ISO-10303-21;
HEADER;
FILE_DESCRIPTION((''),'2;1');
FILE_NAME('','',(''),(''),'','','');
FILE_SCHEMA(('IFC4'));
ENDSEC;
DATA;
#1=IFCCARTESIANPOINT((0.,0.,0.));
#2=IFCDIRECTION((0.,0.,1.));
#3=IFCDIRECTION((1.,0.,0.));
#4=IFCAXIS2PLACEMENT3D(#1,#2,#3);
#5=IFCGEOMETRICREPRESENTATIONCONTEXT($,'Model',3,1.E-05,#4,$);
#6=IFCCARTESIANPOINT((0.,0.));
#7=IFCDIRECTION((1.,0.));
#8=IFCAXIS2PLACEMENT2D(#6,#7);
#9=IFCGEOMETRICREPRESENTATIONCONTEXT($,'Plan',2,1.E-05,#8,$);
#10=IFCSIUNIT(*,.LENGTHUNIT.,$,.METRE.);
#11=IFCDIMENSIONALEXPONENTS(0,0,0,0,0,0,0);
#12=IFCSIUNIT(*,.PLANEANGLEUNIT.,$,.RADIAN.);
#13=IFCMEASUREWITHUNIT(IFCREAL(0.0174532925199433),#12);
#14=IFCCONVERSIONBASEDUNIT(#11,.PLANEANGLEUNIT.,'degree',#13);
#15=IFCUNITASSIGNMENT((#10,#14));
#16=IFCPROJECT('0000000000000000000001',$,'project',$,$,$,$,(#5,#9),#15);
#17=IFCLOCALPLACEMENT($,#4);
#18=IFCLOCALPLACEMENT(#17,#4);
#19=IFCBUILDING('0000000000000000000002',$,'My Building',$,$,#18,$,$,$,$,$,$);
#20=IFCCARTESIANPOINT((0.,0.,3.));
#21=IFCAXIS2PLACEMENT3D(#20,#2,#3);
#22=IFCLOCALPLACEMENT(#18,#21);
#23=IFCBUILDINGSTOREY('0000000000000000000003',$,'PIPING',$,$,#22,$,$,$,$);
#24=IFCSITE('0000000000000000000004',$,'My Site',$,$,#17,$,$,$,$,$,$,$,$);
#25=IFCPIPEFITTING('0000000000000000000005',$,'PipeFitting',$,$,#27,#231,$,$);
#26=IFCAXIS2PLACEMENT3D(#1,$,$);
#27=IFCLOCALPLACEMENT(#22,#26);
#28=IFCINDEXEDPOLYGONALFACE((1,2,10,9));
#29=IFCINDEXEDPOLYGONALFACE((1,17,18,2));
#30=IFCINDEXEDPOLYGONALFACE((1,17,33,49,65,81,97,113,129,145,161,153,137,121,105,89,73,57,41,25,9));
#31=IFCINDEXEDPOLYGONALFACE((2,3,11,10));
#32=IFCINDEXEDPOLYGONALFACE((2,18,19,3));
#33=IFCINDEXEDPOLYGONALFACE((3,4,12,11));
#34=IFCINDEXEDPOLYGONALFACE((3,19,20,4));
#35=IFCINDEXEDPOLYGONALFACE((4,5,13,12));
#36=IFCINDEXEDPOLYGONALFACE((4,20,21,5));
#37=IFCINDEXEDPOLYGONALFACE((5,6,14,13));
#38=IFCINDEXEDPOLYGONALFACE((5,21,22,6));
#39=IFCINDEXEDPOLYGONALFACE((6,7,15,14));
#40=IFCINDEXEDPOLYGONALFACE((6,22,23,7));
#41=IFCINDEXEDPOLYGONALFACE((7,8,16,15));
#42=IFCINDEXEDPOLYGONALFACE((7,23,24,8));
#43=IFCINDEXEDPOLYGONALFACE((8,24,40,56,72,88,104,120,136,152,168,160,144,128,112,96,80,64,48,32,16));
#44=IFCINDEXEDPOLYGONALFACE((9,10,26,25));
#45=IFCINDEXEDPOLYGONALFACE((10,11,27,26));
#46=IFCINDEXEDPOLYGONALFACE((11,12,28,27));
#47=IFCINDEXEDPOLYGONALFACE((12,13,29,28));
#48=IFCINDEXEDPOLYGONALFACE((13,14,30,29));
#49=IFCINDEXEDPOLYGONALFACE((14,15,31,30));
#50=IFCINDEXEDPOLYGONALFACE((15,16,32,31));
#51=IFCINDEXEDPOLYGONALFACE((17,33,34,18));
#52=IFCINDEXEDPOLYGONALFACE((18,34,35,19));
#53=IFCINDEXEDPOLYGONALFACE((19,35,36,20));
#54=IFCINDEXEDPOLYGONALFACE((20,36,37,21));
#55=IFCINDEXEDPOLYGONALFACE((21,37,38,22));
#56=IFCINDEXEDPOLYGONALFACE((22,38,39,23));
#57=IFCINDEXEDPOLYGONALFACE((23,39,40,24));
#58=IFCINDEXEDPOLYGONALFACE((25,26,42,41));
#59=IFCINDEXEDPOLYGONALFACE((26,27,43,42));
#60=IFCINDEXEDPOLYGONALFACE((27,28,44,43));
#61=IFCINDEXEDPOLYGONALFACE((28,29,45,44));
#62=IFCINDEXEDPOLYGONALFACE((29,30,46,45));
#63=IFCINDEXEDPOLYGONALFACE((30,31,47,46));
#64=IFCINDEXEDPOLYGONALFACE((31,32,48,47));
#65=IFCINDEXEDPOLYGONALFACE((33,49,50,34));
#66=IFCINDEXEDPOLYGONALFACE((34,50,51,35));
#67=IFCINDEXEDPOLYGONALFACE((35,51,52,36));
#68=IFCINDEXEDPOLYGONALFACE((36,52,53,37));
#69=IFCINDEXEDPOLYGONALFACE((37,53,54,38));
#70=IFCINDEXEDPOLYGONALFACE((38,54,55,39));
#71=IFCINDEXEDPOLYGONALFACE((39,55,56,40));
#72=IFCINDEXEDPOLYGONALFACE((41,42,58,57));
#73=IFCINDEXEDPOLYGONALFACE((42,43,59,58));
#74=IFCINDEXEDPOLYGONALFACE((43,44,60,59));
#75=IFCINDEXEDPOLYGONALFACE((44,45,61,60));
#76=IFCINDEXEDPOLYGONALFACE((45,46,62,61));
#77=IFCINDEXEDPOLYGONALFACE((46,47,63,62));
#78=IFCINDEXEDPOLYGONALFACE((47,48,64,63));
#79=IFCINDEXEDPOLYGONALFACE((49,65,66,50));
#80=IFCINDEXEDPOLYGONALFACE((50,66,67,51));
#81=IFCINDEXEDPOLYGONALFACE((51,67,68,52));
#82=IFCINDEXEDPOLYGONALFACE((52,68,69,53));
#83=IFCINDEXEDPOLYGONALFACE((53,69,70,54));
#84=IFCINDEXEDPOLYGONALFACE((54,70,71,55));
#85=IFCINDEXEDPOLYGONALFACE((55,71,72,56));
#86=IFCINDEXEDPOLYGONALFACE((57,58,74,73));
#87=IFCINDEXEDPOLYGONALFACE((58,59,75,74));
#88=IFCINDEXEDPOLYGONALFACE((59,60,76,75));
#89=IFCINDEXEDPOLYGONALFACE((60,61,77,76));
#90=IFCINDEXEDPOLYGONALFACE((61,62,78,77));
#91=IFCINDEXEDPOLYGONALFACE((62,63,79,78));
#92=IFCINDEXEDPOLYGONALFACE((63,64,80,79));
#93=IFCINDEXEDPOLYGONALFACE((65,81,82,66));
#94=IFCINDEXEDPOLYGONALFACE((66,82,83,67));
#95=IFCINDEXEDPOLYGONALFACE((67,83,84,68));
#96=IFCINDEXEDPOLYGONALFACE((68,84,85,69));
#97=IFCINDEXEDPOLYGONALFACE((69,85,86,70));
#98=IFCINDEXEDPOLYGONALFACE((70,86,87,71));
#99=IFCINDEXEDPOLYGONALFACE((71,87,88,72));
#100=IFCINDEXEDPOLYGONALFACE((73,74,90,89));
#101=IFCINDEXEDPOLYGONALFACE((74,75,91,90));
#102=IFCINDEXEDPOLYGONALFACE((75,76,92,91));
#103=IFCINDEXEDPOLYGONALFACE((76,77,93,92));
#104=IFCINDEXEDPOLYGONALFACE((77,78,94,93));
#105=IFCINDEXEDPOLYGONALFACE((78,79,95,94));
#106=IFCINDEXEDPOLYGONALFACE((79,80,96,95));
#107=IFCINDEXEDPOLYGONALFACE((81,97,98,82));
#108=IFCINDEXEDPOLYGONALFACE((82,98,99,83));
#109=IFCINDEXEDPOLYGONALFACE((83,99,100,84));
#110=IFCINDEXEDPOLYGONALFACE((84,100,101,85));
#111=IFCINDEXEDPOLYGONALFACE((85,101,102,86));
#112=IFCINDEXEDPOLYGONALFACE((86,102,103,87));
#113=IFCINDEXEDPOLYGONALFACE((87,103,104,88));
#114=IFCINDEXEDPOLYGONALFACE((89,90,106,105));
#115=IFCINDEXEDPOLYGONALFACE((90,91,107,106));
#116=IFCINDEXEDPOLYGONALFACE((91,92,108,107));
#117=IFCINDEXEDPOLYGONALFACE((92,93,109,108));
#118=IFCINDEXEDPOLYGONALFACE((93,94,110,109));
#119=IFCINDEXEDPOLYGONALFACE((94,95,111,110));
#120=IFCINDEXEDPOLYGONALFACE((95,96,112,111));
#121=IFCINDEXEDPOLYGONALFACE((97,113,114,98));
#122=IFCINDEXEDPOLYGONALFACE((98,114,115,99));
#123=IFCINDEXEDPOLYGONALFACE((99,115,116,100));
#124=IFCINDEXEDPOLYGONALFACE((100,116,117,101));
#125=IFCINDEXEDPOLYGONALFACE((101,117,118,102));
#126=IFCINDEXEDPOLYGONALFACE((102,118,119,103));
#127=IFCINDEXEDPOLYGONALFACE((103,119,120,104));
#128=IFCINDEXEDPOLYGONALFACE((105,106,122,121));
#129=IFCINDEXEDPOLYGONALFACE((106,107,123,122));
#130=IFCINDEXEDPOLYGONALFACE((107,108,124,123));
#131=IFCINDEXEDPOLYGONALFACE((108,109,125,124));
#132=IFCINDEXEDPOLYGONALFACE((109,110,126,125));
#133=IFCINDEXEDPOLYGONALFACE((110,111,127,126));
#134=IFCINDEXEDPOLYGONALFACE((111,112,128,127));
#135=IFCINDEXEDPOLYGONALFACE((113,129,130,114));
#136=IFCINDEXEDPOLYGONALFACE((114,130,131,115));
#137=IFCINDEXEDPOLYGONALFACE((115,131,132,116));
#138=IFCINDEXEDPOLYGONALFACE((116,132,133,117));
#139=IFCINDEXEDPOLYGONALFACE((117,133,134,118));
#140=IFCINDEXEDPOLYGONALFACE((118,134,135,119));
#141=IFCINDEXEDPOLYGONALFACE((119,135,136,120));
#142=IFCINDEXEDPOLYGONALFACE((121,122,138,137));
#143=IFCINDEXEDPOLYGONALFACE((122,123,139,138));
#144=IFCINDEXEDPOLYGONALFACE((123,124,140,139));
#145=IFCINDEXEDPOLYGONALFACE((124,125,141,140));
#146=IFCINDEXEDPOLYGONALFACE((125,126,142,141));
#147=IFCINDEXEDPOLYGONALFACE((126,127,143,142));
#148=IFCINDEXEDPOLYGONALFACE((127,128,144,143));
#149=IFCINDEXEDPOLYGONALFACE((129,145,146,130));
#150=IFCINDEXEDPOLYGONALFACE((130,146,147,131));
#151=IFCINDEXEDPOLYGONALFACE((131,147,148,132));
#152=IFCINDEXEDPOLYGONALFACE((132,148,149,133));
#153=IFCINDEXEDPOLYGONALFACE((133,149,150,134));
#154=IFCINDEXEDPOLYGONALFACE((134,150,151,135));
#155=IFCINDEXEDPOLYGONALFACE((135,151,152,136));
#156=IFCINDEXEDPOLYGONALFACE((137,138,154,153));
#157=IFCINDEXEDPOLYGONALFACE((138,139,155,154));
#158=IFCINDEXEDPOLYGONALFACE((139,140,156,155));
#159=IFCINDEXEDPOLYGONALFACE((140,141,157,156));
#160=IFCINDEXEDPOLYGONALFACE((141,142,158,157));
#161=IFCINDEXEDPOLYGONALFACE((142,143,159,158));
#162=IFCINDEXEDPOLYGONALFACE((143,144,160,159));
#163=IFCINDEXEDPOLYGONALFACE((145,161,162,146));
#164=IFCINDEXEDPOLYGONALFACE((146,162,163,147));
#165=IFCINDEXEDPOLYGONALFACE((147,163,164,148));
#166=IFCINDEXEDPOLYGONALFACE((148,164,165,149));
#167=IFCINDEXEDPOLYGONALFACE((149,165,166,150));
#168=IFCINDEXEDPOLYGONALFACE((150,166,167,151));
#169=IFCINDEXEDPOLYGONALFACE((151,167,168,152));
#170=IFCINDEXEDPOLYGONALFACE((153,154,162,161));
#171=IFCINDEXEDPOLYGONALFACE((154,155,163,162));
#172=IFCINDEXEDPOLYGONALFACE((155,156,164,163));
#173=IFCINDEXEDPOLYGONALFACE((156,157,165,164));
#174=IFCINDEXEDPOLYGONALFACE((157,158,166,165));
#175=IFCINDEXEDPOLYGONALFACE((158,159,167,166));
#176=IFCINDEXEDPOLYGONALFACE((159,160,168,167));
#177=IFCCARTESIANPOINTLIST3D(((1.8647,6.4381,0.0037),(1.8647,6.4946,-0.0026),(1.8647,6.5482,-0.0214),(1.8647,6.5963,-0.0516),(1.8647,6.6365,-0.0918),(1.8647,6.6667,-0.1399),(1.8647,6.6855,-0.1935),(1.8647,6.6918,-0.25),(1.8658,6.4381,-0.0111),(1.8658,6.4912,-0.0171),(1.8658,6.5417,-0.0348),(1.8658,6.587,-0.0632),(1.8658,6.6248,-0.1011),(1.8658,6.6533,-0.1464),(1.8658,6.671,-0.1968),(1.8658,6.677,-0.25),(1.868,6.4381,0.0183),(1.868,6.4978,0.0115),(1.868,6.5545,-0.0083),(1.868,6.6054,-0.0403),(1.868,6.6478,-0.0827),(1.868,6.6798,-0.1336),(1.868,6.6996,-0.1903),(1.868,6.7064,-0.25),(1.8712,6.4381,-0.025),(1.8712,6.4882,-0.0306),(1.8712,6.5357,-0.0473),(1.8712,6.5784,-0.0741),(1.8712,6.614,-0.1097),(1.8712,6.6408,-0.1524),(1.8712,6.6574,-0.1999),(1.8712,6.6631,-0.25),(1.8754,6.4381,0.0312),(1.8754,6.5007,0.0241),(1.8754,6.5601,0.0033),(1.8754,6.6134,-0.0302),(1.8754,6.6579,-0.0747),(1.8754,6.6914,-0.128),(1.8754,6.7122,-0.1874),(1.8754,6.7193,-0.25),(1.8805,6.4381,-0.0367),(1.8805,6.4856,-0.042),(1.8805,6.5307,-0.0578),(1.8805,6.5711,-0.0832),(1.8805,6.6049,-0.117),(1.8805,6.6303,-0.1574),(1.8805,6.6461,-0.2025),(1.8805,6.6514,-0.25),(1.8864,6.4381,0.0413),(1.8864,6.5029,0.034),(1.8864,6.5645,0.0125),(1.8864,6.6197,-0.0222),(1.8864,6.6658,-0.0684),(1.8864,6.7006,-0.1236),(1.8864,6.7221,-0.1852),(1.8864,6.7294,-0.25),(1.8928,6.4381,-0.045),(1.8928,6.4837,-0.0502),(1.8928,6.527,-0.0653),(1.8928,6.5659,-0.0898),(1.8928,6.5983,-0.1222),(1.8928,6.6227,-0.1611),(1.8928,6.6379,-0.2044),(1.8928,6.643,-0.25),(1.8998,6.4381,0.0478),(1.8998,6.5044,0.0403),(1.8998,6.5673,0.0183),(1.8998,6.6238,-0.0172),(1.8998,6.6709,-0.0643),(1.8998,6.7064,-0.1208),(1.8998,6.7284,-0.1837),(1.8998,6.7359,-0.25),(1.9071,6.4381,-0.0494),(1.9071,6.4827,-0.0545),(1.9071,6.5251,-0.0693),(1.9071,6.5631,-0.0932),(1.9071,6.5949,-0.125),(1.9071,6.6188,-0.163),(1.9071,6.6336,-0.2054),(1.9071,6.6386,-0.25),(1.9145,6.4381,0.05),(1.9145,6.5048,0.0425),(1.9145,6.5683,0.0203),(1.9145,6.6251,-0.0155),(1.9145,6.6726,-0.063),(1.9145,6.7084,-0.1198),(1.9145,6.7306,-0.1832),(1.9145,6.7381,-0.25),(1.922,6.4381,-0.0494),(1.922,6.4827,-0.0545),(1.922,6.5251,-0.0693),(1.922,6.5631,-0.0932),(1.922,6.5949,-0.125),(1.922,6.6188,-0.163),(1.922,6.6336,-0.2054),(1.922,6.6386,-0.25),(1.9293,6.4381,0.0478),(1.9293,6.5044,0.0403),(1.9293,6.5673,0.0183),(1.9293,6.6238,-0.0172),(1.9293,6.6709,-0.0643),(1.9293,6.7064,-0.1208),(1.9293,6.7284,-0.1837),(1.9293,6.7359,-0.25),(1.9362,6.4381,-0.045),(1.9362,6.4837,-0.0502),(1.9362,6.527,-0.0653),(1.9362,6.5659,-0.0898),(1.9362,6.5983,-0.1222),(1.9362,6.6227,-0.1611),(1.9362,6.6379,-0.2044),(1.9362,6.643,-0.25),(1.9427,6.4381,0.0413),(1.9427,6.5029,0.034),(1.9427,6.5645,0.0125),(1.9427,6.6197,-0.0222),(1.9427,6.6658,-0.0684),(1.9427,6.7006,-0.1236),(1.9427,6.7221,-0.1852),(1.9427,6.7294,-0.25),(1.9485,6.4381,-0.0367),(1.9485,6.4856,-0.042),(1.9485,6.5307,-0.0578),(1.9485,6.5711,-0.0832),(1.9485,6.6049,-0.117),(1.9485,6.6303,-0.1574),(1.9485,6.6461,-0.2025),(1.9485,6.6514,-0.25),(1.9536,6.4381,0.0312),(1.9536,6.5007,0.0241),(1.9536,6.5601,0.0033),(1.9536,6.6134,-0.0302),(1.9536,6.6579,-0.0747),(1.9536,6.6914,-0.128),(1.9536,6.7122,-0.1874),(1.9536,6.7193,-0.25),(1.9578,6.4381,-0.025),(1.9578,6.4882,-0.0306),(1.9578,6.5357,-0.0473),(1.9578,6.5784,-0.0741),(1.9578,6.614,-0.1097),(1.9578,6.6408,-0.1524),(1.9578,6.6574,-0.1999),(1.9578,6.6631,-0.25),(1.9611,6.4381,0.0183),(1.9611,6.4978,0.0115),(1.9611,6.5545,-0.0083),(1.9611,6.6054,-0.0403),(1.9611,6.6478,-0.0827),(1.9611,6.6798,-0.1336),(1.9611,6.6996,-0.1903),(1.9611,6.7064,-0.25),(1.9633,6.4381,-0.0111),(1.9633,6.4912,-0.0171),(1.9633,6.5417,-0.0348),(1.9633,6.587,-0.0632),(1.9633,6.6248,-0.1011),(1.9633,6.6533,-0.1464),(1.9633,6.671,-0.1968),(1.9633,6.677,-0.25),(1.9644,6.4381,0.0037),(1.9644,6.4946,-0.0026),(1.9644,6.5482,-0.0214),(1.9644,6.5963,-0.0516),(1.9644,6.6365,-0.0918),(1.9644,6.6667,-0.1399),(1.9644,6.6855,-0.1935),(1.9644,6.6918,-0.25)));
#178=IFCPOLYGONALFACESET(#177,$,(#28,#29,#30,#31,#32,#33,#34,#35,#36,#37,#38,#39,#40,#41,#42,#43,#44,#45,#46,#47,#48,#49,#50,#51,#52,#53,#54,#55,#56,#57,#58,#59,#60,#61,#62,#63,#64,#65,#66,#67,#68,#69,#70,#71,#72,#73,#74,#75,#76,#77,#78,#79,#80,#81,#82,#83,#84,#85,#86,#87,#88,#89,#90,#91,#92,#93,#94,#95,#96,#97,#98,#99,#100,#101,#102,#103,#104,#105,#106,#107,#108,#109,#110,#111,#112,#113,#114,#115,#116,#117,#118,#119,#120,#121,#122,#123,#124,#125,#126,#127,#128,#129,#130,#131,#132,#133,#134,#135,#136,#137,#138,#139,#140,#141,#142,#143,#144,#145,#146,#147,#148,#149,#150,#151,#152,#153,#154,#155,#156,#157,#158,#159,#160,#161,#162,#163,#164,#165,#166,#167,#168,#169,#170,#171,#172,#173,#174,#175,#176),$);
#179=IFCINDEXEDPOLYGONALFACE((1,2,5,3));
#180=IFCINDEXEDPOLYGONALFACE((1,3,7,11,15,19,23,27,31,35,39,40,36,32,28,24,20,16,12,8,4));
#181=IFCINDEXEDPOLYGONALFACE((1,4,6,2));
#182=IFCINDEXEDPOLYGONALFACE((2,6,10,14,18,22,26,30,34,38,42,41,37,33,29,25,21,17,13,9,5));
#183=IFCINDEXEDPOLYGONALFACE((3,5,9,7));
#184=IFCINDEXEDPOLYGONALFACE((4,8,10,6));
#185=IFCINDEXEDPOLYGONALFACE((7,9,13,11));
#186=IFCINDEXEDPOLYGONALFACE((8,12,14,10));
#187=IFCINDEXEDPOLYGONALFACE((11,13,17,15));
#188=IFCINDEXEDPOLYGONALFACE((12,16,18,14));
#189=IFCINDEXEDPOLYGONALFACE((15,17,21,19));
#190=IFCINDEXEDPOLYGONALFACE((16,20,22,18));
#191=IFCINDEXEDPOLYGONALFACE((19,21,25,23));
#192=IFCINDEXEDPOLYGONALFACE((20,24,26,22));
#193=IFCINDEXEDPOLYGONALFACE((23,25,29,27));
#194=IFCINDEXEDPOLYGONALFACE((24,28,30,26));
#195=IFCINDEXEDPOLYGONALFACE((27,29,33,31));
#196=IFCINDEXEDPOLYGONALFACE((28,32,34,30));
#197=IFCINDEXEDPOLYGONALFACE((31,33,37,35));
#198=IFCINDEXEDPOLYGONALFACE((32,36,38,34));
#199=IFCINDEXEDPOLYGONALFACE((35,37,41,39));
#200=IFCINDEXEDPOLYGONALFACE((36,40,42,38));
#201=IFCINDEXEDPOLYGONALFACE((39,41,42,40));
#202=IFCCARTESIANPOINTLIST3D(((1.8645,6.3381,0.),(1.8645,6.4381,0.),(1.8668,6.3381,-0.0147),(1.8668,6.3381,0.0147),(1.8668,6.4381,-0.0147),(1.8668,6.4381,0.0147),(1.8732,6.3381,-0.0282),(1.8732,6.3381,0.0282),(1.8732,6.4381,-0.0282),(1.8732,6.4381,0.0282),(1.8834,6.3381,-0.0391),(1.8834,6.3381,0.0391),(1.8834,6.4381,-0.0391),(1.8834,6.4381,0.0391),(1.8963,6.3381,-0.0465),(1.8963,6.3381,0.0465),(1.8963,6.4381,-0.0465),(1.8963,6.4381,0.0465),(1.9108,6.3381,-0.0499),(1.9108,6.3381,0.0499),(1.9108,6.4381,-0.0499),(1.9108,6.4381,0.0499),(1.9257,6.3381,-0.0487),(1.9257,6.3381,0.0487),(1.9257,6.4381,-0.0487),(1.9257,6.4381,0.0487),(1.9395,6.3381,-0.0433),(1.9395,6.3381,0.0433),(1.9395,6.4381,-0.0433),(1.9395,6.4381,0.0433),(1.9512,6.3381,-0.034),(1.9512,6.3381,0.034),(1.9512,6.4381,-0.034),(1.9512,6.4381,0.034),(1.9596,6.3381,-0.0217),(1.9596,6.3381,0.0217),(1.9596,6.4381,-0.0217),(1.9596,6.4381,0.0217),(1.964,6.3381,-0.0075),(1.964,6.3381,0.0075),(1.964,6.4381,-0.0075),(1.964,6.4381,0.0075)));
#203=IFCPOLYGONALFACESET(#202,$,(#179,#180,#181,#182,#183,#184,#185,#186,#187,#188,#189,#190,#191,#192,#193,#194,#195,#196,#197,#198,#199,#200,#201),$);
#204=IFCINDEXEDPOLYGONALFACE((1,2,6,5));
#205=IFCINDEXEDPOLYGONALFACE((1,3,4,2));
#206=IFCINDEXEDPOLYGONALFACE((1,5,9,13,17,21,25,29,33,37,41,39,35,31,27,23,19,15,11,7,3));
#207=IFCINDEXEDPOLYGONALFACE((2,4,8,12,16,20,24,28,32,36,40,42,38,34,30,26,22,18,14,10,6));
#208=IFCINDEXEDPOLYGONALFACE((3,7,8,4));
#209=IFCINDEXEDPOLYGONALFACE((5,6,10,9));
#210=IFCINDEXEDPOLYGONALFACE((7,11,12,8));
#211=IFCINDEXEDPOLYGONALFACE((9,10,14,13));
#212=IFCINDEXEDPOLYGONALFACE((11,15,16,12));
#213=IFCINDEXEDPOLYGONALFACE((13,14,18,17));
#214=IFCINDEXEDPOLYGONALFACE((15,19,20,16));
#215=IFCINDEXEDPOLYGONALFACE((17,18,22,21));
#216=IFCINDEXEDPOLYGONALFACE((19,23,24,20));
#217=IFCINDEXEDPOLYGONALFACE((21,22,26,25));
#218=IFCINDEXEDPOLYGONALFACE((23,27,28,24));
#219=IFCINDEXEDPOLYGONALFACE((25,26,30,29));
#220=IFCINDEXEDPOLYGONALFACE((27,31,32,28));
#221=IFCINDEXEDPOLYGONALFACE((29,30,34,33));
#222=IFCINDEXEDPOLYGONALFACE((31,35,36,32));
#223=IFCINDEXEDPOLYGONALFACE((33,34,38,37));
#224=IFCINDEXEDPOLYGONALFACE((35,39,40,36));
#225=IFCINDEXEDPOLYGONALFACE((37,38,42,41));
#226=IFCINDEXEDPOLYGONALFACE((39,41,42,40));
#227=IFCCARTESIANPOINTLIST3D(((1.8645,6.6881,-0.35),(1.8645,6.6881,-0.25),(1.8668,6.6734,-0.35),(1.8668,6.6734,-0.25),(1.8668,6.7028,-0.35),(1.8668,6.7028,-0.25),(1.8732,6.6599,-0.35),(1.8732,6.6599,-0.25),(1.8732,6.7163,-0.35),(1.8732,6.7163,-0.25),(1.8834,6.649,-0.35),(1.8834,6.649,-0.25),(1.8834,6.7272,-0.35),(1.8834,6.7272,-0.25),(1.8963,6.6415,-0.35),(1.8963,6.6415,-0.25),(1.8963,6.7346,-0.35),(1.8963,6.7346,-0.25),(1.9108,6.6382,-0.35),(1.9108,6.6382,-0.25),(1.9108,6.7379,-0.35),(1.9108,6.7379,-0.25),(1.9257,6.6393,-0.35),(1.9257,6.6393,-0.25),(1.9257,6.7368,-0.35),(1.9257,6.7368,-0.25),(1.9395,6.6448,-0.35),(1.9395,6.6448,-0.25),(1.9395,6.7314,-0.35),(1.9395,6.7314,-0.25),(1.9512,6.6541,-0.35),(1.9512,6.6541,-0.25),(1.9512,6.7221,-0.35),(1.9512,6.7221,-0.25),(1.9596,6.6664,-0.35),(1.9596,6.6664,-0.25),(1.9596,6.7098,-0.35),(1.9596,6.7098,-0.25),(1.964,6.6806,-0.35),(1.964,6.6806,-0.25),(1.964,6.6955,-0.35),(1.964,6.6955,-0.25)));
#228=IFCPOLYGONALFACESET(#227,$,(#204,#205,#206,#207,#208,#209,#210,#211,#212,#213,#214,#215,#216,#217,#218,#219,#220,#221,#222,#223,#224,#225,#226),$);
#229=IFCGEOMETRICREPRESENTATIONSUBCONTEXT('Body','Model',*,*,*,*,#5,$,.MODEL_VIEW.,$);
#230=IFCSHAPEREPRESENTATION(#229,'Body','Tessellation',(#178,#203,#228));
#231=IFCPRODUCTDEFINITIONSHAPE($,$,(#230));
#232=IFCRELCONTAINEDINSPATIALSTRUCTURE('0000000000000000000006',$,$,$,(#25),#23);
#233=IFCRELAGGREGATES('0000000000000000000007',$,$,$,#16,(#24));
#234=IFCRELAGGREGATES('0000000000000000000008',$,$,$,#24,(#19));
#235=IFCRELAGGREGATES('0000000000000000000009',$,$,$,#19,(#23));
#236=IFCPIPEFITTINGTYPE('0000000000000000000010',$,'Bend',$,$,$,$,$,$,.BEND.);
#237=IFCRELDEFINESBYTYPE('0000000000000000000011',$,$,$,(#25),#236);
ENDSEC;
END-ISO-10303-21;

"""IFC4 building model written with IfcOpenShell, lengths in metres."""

from ifc_helpers import new_model, entity, si_unit, converted_unit, frame, origin_with_axes, origin_2d_with_axis, place, context, subcontext, project, spatial, circle, extrude, source, transform, mapped, type_object, type_shapes, element, save


model = new_model("IFC4")

# Units and contexts
model_context = context("Model", 3, precision=1e-05, world=origin_with_axes())
plan_context = context("Plan", 2, precision=1e-05, world=origin_2d_with_axis())
body_context = subcontext(model_context, "Body", "Model", "MODEL_VIEW")
ifc_project = project(units=[si_unit("LENGTHUNIT", "METRE"), converted_unit("PLANEANGLEUNIT", "degree", entity("IfcReal", 0.0174532925199433), si_unit("PLANEANGLEUNIT", "RADIAN"), dimensions=[0, 0, 0, 0, 0, 0, 0])], contexts=[model_context, plan_context])

# Site, building, storey
site_placement = place(None, origin_with_axes())
site = spatial("IfcSite", under=ifc_project, at=site_placement, Name="My Site")
building_placement = place(site_placement, origin_with_axes())
building = spatial("IfcBuilding", under=site, at=building_placement, Name="My Building")
storey_placement = place(building_placement, frame((0.0, 0.0, 3.0), z_axis=(0.0, 0.0, 1.0), x_axis=(1.0, 0.0, 0.0)))
storey = spatial("IfcBuildingStorey", under=building, at=storey_placement, Name="PIPING")

# Pipe fitting
pipe_fitting_type = type_object("IfcPipeFittingType", Name="Bend", PredefinedType="BEND")
shared_shape = source(origin_with_axes(), body_context, "Body", "SolidModel", [
    entity("IfcSweptDiskSolid", entity("IfcIndexedPolyCurve", entity("IfcCartesianPointList3D", [[0.0, 0.0, 0.1], [0.0, -0.0732, 0.2768], [0.0, -0.25, 0.35]]), [entity("IfcArcIndex", [1, 2, 3])]), 0.05),
    extrude(circle(Radius=0.05), origin_with_axes(), (0.0, 0.0, 1.0), 0.1),
    extrude(circle(Radius=0.05), frame((0.0, -0.25, 0.35), z_axis=(0.0, -1.0, 0.0), x_axis=(1.0, 0.0, 0.0)), (0.0, 0.0, 1.0), 0.1),
])
type_shapes(pipe_fitting_type, [shared_shape])
for number, where, z_axis, x_axis, name in (
    (1, (1.9145, 6.3381, 0.0), (0.0, 1.0, 0.0), (-1.0, 0.0, 0.0), "PipeFitting"),
):
    element("IfcPipeFitting", number, at=place(storey_placement, frame(where, z_axis=z_axis, x_axis=x_axis)), inside=storey, type_object=pipe_fitting_type, Name=name, context=body_context, shape_type="MappedRepresentation", body=[
        mapped(shared_shape, transform((0.0, 0.0, 0.0), x_axis=(1.0, 0.0, 0.0), y_axis=(0.0, 1.0, 0.0), z_axis=(0.0, 0.0, 1.0), scale=1.0)),
    ])

save(model, "model.ifc")
